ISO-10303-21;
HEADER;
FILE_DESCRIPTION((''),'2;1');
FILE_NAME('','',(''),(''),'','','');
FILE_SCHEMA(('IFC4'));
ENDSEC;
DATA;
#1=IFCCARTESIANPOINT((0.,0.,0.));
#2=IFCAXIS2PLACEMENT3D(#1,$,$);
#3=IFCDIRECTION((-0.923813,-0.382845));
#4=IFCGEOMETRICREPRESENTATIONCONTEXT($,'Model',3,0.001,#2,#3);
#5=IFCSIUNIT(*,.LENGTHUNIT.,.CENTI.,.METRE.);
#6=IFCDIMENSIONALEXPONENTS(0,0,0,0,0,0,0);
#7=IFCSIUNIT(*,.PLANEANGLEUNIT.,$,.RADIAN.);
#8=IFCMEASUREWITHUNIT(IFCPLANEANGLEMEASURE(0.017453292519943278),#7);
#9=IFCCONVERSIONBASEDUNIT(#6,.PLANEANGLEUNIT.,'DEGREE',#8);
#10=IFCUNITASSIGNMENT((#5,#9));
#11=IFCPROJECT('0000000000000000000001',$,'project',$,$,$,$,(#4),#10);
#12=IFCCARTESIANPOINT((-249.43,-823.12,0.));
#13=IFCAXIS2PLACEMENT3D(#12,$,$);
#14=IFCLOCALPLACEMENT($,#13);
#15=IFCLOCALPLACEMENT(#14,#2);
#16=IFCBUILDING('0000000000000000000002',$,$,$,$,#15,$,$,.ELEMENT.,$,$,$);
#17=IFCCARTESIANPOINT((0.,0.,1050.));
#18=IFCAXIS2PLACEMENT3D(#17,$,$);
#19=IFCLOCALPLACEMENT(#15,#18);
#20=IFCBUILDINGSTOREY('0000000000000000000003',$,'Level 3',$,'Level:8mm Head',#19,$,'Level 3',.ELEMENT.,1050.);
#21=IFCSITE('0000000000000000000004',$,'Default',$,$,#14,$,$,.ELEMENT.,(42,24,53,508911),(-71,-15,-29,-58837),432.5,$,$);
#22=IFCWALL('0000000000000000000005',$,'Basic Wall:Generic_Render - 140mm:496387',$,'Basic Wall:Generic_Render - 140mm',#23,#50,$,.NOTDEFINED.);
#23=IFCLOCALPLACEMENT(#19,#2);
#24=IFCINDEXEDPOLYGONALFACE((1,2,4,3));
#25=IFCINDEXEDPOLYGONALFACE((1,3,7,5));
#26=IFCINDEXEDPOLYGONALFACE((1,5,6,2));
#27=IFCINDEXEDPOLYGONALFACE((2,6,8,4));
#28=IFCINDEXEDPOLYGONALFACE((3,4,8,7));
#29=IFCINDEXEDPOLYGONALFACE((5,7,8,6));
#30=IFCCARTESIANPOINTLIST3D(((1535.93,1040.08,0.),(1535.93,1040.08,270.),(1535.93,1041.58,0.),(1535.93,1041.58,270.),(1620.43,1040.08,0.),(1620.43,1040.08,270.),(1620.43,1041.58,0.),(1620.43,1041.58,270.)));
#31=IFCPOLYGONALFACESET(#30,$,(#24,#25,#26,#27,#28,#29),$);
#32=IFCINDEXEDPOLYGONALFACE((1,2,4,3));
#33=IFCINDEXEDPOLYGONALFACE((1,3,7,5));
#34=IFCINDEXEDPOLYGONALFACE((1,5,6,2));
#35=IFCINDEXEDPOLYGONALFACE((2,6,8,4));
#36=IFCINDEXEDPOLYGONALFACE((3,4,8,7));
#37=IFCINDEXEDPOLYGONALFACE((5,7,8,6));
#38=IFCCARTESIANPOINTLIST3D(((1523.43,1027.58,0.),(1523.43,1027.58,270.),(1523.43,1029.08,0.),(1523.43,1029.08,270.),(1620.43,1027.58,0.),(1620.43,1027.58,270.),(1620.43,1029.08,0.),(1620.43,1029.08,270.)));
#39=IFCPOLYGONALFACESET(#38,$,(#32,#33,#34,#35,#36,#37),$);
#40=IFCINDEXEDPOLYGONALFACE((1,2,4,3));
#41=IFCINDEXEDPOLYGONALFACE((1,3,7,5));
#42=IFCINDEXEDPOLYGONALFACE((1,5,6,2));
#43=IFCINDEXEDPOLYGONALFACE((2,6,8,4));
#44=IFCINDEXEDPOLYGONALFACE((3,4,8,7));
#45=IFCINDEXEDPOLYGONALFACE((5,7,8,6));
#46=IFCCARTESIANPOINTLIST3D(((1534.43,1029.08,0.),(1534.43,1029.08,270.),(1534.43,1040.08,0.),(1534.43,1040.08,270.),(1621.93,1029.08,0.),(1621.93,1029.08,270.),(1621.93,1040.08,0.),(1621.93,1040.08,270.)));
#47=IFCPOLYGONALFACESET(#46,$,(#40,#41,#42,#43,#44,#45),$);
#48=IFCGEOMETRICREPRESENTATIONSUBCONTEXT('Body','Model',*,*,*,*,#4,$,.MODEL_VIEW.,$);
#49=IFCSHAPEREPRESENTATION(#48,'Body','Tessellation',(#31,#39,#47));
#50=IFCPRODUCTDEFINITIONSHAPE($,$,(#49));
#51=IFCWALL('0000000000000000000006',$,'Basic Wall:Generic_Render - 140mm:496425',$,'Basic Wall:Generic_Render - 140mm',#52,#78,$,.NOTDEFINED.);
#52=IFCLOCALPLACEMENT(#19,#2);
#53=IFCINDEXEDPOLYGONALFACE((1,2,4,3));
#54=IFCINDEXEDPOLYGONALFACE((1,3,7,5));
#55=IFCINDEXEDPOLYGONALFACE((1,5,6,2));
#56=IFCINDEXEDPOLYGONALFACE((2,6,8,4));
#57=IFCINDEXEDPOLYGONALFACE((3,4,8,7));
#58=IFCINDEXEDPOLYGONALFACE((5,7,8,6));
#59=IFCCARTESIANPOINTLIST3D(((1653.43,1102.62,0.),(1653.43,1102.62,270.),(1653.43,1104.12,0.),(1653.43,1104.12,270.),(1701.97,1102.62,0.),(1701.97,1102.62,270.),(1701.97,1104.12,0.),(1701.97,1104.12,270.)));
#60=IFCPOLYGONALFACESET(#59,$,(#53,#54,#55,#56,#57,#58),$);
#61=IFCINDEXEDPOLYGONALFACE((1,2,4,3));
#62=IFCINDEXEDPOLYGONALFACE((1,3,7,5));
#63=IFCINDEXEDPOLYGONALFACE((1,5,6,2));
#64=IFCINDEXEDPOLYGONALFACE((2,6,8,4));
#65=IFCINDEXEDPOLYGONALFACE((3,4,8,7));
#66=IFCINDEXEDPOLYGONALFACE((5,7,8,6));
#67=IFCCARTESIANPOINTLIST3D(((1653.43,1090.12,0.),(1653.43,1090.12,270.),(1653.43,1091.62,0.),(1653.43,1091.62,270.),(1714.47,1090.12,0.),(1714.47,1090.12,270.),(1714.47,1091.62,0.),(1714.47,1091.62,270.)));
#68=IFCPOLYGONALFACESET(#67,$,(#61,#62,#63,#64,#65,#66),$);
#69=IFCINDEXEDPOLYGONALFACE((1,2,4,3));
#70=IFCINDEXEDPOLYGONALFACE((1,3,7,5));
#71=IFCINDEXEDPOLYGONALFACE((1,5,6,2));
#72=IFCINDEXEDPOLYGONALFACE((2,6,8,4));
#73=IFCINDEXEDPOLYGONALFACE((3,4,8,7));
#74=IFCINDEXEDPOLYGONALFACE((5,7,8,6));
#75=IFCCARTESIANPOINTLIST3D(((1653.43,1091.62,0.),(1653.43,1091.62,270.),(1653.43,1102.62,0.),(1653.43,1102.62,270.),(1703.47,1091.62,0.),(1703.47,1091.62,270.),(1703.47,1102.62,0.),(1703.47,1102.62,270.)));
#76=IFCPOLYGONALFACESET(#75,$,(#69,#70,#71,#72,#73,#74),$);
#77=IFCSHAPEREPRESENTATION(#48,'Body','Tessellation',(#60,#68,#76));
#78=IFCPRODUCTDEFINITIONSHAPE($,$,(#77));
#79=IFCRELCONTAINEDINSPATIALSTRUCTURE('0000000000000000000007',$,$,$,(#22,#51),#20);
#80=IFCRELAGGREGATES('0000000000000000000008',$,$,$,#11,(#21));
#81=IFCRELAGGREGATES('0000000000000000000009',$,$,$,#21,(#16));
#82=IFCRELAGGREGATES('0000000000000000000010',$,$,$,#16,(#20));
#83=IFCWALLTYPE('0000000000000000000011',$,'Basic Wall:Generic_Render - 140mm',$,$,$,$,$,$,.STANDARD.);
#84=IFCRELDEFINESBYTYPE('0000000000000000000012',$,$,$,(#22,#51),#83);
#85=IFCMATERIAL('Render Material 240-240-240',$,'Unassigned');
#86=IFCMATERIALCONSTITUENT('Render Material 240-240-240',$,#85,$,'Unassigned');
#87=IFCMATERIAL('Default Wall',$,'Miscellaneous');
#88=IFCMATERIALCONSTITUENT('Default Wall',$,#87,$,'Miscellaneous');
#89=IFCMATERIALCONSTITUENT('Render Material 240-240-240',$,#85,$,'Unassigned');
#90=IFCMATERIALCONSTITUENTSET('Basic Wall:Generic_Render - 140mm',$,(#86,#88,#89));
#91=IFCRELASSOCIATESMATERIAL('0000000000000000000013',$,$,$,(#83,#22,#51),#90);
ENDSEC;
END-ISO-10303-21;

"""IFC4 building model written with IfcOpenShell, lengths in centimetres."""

from ifc_helpers import new_model, entity, si_unit, converted_unit, direction, frame, origin, place, context, subcontext, project, spatial, indexed_curve, outline, extrude, material, constituent, constituent_set, type_object, element, save


model = new_model("IFC4")

# Units and contexts
model_context = context("Model", 3, precision=0.001, world=origin(), true_north=direction((-0.923813, -0.382845)))
body_context = subcontext(model_context, "Body", "Model", "MODEL_VIEW")
ifc_project = project(units=[si_unit("LENGTHUNIT", "METRE", prefix="CENTI"), converted_unit("PLANEANGLEUNIT", "DEGREE", entity("IfcPlaneAngleMeasure", 0.017453292519943278), si_unit("PLANEANGLEUNIT", "RADIAN"), dimensions=[0, 0, 0, 0, 0, 0, 0])], contexts=[model_context])

# Site, building, storey
site_placement = place(None, frame((-249.43, -823.12, 0.0)))
site = spatial("IfcSite", under=ifc_project, at=site_placement, Name="Default", CompositionType="ELEMENT", RefLatitude=(42, 24, 53, 508911), RefLongitude=(-71, -15, -29, -58837), RefElevation=432.5)
building_placement = place(site_placement, origin())
building = spatial("IfcBuilding", under=site, at=building_placement, CompositionType="ELEMENT")
storey_placement = place(building_placement, frame((0.0, 0.0, 1050.0)))
storey = spatial("IfcBuildingStorey", under=building, at=storey_placement, Name="Level 3", ObjectType="Level:8mm Head", LongName="Level 3", CompositionType="ELEMENT", Elevation=1050.0)

# Walls
ifc_material_1 = material(Name="Render Material 240-240-240", Category="Unassigned")
ifc_material_2 = material(Name="Default Wall", Category="Miscellaneous")
ifc_constituent_1 = constituent(ifc_material_1, Name="Render Material 240-240-240", Category="Unassigned")
ifc_constituent_2 = constituent(ifc_material_2, Name="Default Wall", Category="Miscellaneous")
ifc_constituent_3 = constituent(ifc_material_1, Name="Render Material 240-240-240", Category="Unassigned")
ifc_constituent_set_1 = constituent_set(constituents=[ifc_constituent_1, ifc_constituent_2, ifc_constituent_3], Name="Basic Wall:Generic_Render - 140mm")
wall_type_1 = type_object("IfcWallType", Name="Basic Wall:Generic_Render - 140mm", PredefinedType="STANDARD", material=ifc_constituent_set_1)
wall_1_placement = place(storey_placement, frame((1535.93, 1034.58, 0.0)))
element("IfcWall", 1, at=wall_1_placement, inside=storey, type_object=wall_type_1, material=ifc_constituent_set_1, Name="Basic Wall:Generic_Render - 140mm:496387", ObjectType="Basic Wall:Generic_Render - 140mm", PredefinedType="NOTDEFINED", context=body_context, shape_type="SweptSolid", body=[
    extrude(outline(indexed_curve([(-0.75, -42.25), (0.75, -42.25), (0.75, 42.25), (-0.75, 42.25), (-0.75, -42.25)], self_intersect=False)), frame((42.25, 6.25, 0.0), z_axis=(0.0, 0.0, 1.0), x_axis=(0.0, -1.0, 0.0)), (0.0, 0.0, 1.0), 270.0),
    extrude(outline(indexed_curve([(-0.75, -48.5), (0.75, -48.5), (0.75, 48.5), (-0.75, 48.5), (-0.75, -48.5)], self_intersect=False)), frame((36.0, -6.25, 0.0), z_axis=(0.0, 0.0, 1.0), x_axis=(0.0, 1.0, 0.0)), (0.0, 0.0, 1.0), 270.0),
    extrude(outline(indexed_curve([(-43.75, -5.5), (43.75, -5.5), (43.75, 5.5), (-43.75, 5.5), (-43.75, -5.5)], self_intersect=False)), frame((42.25, 0.0, 0.0)), (0.0, 0.0, 1.0), 270.0),
])
wall_2_placement = place(storey_placement, frame((1701.97, 1097.12, 0.0), z_axis=(0.0, 0.0, 1.0), x_axis=(-1.0, 0.0, 0.0)))
element("IfcWall", 2, at=wall_2_placement, inside=storey, type_object=wall_type_1, material=ifc_constituent_set_1, Name="Basic Wall:Generic_Render - 140mm:496425", ObjectType="Basic Wall:Generic_Render - 140mm", PredefinedType="NOTDEFINED", context=body_context, shape_type="SweptSolid", body=[
    extrude(outline(indexed_curve([(-0.75, -24.27), (0.75, -24.27), (0.75, 24.27), (-0.75, 24.27), (-0.75, -24.27)], self_intersect=False)), frame((24.27, -6.25, 0.0), z_axis=(0.0, 0.0, 1.0), x_axis=(0.0, 1.0, 0.0)), (0.0, 0.0, 1.0), 270.0),
    extrude(outline(indexed_curve([(-0.75, -30.52), (0.75, -30.52), (0.75, 30.52), (-0.75, 30.52), (-0.75, -30.52)], self_intersect=False)), frame((18.02, 6.25, 0.0), z_axis=(0.0, 0.0, 1.0), x_axis=(0.0, -1.0, 0.0)), (0.0, 0.0, 1.0), 270.0),
    extrude(outline(indexed_curve([(-25.02, -5.5), (25.02, -5.5), (25.02, 5.5), (-25.02, 5.5), (-25.02, -5.5)], self_intersect=False)), frame((23.52, 0.0, 0.0)), (0.0, 0.0, 1.0), 270.0),
])

save(model, "model.ifc")
